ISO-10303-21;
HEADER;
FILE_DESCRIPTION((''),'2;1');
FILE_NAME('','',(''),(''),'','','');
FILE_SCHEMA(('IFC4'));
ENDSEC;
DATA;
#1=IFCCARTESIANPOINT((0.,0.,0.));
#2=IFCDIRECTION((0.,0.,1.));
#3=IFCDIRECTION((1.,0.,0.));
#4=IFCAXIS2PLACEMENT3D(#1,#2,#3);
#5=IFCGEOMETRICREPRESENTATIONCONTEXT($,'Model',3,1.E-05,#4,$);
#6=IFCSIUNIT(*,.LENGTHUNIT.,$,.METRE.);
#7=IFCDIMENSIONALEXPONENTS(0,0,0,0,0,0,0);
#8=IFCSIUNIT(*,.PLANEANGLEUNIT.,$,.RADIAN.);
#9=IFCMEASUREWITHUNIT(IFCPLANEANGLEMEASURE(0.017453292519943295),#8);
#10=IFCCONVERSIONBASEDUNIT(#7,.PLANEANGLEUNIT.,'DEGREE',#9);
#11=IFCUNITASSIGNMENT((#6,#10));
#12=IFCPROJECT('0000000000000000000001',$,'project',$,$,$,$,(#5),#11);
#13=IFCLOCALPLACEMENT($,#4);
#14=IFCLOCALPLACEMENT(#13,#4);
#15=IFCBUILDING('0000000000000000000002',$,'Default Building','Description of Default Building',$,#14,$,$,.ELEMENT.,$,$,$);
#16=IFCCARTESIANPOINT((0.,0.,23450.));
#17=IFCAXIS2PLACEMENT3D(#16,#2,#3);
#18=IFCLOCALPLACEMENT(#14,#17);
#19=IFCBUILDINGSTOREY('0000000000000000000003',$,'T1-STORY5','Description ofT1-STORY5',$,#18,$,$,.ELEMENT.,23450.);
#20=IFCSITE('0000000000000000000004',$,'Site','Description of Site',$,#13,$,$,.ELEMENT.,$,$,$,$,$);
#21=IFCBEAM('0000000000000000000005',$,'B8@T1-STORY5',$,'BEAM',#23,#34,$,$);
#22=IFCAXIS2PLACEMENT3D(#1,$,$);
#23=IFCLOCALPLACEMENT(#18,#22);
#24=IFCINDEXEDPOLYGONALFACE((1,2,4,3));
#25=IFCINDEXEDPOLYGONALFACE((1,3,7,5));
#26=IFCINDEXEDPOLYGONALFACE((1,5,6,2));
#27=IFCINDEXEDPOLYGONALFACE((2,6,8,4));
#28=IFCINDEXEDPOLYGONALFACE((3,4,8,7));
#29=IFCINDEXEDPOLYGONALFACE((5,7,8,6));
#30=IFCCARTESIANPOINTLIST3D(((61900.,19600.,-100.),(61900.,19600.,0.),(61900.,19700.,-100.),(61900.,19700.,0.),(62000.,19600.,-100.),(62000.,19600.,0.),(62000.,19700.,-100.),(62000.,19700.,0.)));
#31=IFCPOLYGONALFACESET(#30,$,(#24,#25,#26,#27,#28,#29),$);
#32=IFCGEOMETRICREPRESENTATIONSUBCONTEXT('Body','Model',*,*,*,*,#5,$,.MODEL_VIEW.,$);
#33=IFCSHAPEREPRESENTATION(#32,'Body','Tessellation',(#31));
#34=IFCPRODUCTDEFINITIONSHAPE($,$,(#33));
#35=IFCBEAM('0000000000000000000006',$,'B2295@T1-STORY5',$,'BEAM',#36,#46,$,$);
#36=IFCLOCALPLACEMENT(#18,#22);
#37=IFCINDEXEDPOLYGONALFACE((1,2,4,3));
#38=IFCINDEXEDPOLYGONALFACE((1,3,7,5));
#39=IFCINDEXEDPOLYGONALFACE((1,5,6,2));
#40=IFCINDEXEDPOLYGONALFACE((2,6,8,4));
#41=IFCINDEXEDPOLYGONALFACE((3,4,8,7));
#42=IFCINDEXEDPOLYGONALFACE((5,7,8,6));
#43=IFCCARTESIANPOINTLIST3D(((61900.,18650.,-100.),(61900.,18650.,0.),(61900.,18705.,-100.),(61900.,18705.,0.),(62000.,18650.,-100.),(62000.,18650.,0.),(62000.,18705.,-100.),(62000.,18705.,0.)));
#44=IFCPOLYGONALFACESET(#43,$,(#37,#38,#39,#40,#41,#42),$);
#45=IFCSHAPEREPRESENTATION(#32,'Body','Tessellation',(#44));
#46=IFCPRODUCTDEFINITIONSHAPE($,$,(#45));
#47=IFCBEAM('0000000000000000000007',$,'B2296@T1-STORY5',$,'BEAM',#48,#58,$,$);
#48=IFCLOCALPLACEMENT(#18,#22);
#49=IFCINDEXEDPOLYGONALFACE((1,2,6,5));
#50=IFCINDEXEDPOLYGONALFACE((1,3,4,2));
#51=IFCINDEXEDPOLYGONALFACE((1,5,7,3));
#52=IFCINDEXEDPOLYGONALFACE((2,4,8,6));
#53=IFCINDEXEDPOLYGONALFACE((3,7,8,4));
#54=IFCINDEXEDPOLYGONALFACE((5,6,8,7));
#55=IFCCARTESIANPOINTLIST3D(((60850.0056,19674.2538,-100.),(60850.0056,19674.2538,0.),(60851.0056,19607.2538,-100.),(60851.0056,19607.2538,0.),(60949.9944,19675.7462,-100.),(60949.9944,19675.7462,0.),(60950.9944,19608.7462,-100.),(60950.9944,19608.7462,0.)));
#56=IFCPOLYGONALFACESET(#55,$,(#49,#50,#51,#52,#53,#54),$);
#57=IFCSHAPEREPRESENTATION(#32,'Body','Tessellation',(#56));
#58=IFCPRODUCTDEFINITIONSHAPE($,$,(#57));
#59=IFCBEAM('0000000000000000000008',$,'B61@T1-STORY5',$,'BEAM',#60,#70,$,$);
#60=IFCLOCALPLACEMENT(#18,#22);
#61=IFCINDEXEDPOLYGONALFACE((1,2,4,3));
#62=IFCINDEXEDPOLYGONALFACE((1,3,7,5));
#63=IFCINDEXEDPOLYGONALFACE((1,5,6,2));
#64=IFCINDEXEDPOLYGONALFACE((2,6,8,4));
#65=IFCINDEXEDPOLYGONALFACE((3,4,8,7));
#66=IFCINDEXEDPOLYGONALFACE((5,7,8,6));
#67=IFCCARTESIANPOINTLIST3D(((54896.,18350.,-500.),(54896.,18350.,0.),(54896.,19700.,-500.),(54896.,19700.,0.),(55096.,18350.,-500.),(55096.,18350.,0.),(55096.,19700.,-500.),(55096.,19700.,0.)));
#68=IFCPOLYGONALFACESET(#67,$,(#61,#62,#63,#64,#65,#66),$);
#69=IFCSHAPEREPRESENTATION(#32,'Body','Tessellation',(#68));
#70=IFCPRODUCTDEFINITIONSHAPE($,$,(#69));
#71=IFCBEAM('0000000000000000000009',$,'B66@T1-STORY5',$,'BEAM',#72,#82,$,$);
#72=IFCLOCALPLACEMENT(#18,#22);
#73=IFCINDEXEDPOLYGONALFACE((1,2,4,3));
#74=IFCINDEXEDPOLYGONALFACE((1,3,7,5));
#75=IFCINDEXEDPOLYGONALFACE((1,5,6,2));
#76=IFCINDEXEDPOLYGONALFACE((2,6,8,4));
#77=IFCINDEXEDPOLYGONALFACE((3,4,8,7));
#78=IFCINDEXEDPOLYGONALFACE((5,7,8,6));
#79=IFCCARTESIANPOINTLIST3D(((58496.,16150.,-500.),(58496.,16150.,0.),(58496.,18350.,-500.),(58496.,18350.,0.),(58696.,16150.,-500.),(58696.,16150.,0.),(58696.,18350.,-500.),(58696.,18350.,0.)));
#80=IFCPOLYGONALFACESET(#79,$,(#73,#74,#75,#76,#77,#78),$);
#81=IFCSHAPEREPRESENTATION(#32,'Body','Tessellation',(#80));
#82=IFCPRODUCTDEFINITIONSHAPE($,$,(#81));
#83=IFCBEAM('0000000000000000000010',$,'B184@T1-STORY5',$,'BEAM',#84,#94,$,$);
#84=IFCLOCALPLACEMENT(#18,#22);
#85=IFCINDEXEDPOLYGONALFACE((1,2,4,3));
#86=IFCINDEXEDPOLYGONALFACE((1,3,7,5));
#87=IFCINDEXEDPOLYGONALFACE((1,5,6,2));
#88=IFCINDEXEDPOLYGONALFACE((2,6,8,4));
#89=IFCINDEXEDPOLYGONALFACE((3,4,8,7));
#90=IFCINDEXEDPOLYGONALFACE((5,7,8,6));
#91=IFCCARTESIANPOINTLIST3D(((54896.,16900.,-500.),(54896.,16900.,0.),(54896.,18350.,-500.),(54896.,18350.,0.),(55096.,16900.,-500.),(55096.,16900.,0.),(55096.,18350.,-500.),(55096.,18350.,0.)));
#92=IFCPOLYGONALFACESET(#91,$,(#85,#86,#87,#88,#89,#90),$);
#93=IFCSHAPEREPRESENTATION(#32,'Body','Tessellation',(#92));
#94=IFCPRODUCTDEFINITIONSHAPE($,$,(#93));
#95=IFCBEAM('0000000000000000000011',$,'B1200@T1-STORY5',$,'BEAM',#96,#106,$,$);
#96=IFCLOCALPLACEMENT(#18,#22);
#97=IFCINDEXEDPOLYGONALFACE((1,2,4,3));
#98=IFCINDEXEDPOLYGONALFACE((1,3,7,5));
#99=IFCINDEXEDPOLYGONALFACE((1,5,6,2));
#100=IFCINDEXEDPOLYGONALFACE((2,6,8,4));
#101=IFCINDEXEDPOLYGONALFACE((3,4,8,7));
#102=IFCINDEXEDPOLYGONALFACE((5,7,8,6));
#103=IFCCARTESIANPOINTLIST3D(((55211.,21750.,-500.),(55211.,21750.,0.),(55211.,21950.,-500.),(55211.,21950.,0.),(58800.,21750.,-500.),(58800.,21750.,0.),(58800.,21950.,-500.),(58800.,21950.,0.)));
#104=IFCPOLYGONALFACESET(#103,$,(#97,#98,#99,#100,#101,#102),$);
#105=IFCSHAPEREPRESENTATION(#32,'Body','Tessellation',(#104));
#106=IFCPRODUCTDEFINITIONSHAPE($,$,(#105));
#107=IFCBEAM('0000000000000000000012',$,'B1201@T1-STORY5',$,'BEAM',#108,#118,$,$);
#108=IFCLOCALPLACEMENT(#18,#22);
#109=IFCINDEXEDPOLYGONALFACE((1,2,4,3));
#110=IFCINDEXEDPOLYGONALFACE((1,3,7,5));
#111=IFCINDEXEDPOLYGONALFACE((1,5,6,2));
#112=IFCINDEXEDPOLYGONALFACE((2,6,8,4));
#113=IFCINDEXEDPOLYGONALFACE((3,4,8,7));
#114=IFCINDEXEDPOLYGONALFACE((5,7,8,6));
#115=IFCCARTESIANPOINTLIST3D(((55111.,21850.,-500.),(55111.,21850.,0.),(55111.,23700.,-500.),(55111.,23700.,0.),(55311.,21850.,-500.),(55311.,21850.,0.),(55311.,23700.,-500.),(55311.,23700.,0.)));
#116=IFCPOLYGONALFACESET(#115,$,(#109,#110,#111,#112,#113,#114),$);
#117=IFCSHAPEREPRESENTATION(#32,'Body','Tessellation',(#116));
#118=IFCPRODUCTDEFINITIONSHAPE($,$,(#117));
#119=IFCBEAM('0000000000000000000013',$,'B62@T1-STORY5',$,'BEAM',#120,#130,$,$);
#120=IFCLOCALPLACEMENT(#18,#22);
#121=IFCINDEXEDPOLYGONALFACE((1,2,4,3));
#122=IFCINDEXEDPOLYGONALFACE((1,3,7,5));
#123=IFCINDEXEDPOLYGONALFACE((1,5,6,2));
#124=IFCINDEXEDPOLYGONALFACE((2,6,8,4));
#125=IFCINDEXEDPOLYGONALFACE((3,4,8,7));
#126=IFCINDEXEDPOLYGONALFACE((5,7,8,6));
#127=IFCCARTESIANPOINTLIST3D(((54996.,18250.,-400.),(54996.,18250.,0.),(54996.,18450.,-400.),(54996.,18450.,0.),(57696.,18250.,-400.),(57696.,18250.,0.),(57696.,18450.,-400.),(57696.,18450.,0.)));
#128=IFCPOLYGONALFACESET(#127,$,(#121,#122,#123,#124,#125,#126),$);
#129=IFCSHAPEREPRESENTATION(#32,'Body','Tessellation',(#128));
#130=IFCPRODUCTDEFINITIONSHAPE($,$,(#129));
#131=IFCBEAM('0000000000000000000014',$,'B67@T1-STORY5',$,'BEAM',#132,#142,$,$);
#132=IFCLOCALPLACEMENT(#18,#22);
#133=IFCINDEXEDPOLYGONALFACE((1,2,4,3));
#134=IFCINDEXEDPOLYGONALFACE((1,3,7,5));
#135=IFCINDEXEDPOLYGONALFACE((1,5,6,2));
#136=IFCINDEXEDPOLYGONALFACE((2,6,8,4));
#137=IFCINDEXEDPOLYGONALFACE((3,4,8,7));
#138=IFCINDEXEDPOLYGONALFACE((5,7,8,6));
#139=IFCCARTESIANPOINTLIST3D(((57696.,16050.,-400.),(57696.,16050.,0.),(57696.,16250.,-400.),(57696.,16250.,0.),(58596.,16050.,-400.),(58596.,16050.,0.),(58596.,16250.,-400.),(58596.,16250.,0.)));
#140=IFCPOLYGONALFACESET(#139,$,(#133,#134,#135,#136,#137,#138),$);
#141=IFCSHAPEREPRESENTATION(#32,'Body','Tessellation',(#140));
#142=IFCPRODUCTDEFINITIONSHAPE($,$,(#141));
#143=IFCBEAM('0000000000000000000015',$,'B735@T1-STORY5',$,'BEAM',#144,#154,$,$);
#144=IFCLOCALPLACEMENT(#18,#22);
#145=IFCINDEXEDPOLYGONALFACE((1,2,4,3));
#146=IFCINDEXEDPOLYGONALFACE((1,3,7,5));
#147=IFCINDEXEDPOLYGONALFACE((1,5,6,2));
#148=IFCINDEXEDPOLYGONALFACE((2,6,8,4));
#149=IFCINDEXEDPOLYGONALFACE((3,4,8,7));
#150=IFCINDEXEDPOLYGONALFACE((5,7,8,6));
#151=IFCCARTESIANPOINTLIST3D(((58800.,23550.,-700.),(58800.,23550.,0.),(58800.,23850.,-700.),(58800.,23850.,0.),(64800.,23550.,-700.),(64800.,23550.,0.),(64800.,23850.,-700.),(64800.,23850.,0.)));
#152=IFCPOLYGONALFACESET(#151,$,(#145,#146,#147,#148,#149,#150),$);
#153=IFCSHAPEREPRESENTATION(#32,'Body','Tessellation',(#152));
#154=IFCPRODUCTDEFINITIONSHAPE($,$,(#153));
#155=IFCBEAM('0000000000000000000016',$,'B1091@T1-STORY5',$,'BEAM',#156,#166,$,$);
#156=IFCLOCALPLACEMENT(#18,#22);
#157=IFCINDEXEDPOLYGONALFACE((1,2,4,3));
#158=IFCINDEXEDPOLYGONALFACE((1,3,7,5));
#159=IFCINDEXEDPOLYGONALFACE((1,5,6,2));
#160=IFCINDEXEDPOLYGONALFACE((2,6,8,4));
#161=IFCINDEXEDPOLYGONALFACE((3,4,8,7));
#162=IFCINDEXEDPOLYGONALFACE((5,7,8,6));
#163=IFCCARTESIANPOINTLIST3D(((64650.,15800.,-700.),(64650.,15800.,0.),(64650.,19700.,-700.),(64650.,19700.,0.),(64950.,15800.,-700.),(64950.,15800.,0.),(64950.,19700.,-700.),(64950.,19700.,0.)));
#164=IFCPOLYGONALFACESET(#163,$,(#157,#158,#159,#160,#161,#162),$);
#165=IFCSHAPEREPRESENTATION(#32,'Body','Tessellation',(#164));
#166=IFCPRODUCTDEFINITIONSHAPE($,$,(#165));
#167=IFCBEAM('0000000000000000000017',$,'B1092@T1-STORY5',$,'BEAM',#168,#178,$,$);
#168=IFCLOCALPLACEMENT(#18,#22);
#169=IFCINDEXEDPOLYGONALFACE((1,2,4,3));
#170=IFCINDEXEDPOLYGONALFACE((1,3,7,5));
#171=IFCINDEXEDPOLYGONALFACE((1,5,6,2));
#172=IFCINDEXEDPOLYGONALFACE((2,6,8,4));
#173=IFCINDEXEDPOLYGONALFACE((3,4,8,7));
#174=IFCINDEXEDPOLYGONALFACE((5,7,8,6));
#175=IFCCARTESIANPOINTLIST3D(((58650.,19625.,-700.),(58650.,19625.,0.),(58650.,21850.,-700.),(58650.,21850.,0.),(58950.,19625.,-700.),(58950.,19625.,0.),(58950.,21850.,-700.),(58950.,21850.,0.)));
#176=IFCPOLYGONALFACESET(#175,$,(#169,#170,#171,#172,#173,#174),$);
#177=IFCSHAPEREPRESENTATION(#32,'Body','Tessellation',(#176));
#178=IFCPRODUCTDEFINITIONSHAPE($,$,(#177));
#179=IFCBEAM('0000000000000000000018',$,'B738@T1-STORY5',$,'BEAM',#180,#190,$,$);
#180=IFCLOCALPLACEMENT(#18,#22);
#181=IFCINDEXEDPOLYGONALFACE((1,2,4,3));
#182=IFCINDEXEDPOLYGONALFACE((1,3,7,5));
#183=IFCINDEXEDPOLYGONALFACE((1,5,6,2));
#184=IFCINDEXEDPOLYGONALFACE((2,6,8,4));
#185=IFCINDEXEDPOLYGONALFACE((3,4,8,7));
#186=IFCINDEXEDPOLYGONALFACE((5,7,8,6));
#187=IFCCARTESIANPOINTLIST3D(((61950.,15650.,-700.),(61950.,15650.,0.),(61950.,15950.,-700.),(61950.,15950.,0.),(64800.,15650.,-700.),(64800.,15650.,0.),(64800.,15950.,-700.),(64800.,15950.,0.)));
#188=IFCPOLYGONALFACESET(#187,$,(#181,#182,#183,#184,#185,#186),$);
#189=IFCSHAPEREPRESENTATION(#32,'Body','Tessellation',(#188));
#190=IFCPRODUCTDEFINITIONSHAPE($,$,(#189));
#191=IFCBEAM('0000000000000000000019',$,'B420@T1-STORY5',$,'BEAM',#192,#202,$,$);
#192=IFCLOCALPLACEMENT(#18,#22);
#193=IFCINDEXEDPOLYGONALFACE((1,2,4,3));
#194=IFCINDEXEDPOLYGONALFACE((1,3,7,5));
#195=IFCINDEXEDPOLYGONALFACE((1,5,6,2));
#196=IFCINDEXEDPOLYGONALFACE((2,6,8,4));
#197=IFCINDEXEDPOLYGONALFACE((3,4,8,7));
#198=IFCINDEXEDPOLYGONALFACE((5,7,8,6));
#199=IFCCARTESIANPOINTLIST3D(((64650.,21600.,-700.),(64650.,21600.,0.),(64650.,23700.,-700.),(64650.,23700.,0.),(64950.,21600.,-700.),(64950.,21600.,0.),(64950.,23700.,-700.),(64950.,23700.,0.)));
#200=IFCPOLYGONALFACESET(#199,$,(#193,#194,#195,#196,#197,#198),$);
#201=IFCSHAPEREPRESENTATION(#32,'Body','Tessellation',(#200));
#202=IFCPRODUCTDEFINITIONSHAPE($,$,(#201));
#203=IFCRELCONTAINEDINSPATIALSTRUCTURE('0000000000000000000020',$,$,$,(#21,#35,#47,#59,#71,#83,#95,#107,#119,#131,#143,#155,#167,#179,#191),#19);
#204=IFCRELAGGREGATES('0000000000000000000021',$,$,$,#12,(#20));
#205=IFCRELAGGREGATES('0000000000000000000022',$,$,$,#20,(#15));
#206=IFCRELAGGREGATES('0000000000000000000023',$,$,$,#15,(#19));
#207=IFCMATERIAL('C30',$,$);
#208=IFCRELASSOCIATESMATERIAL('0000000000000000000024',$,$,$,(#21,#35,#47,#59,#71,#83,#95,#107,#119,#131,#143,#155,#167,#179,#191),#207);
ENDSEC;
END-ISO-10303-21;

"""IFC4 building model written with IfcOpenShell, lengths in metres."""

from ifc_helpers import new_model, entity, si_unit, converted_unit, frame, origin_with_axes, place, context, subcontext, project, spatial, rectangle, extrude, material, element, save


model = new_model("IFC4")

# Units and contexts
model_context = context("Model", 3, precision=1e-05, world=origin_with_axes())
body_context = subcontext(model_context, "Body", "Model", "MODEL_VIEW")
ifc_project = project(units=[si_unit("LENGTHUNIT", "METRE"), converted_unit("PLANEANGLEUNIT", "DEGREE", entity("IfcPlaneAngleMeasure", 0.017453292519943295), si_unit("PLANEANGLEUNIT", "RADIAN"), dimensions=[0, 0, 0, 0, 0, 0, 0])], contexts=[model_context])

# Site, building, storey
site_placement = place(None, origin_with_axes())
site = spatial("IfcSite", under=ifc_project, at=site_placement, Name="Site", Description="Description of Site", CompositionType="ELEMENT")
building_placement = place(site_placement, origin_with_axes())
building = spatial("IfcBuilding", under=site, at=building_placement, Name="Default Building", Description="Description of Default Building", CompositionType="ELEMENT")
storey_placement = place(building_placement, frame((0.0, 0.0, 23450.0), z_axis=(0.0, 0.0, 1.0), x_axis=(1.0, 0.0, 0.0)))
storey = spatial("IfcBuildingStorey", under=building, at=storey_placement, Name="T1-STORY5", Description="Description ofT1-STORY5", CompositionType="ELEMENT", Elevation=23450.0)

# Beams
ifc_material_1 = material(Name="C30")
beam_1_placement = place(storey_placement, frame((61950.0, 19600.0, -50.0), z_axis=(0.0, 1.0, 0.0), x_axis=(-1.0, 0.0, 0.0)))
element("IfcBeam", 1, at=beam_1_placement, inside=storey, material=ifc_material_1, Name="B8@T1-STORY5", ObjectType="BEAM", context=body_context, shape_type="SweptSolid", body=[
    extrude(rectangle(XDim=100.0, YDim=100.0), origin_with_axes(), (0.0, 0.0, 1.0), 100.0),
])
beam_2_placement = place(storey_placement, frame((61950.0, 18650.0, -50.0), z_axis=(0.0, 1.0, 0.0), x_axis=(-1.0, 0.0, 0.0)))
element("IfcBeam", 2, at=beam_2_placement, inside=storey, material=ifc_material_1, Name="B2295@T1-STORY5", ObjectType="BEAM", context=body_context, shape_type="SweptSolid", body=[
    extrude(rectangle(XDim=100.0, YDim=100.0), origin_with_axes(), (0.0, 0.0, 1.0), 55.0),
])
beam_3_placement = place(storey_placement, frame((60901.0, 19608.0, -50.0), z_axis=(-0.014924, 0.999889, 0.0), x_axis=(-0.999889, -0.014924, 0.0)))
element("IfcBeam", 3, at=beam_3_placement, inside=storey, material=ifc_material_1, Name="B2296@T1-STORY5", ObjectType="BEAM", context=body_context, shape_type="SweptSolid", body=[
    extrude(rectangle(XDim=100.0, YDim=100.0), origin_with_axes(), (0.0, 0.0, 1.0), 67.0075),
])
beam_4_placement = place(storey_placement, frame((54996.0, 18350.0, -250.0), z_axis=(0.0, 1.0, 0.0), x_axis=(-1.0, 0.0, 0.0)))
element("IfcBeam", 4, at=beam_4_placement, inside=storey, material=ifc_material_1, Name="B61@T1-STORY5", ObjectType="BEAM", context=body_context, shape_type="SweptSolid", body=[
    extrude(rectangle(XDim=200.0, YDim=500.0), origin_with_axes(), (0.0, 0.0, 1.0), 1350.0),
])
beam_5_placement = place(storey_placement, frame((58596.0, 16150.0, -250.0), z_axis=(0.0, 1.0, 0.0), x_axis=(-1.0, 0.0, 0.0)))
element("IfcBeam", 5, at=beam_5_placement, inside=storey, material=ifc_material_1, Name="B66@T1-STORY5", ObjectType="BEAM", context=body_context, shape_type="SweptSolid", body=[
    extrude(rectangle(XDim=200.0, YDim=500.0), origin_with_axes(), (0.0, 0.0, 1.0), 2200.0),
])
beam_6_placement = place(storey_placement, frame((54996.0, 16900.0, -250.0), z_axis=(0.0, 1.0, 0.0), x_axis=(-1.0, 0.0, 0.0)))
element("IfcBeam", 6, at=beam_6_placement, inside=storey, material=ifc_material_1, Name="B184@T1-STORY5", ObjectType="BEAM", context=body_context, shape_type="SweptSolid", body=[
    extrude(rectangle(XDim=200.0, YDim=500.0), origin_with_axes(), (0.0, 0.0, 1.0), 1450.0),
])
beam_7_placement = place(storey_placement, frame((55211.0, 21850.0, -250.0), z_axis=(1.0, 0.0, 0.0), x_axis=(0.0, 1.0, 0.0)))
element("IfcBeam", 7, at=beam_7_placement, inside=storey, material=ifc_material_1, Name="B1200@T1-STORY5", ObjectType="BEAM", context=body_context, shape_type="SweptSolid", body=[
    extrude(rectangle(XDim=200.0, YDim=500.0), origin_with_axes(), (0.0, 0.0, 1.0), 3589.0),
])
beam_8_placement = place(storey_placement, frame((55211.0, 21850.0, -250.0), z_axis=(0.0, 1.0, 0.0), x_axis=(-1.0, 0.0, 0.0)))
element("IfcBeam", 8, at=beam_8_placement, inside=storey, material=ifc_material_1, Name="B1201@T1-STORY5", ObjectType="BEAM", context=body_context, shape_type="SweptSolid", body=[
    extrude(rectangle(XDim=200.0, YDim=500.0), origin_with_axes(), (0.0, 0.0, 1.0), 1850.0),
])
beam_9_placement = place(storey_placement, frame((54996.0, 18350.0, -200.0), z_axis=(1.0, 0.0, 0.0), x_axis=(0.0, 1.0, 0.0)))
element("IfcBeam", 9, at=beam_9_placement, inside=storey, material=ifc_material_1, Name="B62@T1-STORY5", ObjectType="BEAM", context=body_context, shape_type="SweptSolid", body=[
    extrude(rectangle(XDim=200.0, YDim=400.0), origin_with_axes(), (0.0, 0.0, 1.0), 2700.0),
])
beam_10_placement = place(storey_placement, frame((57696.0, 16150.0, -200.0), z_axis=(1.0, 0.0, 0.0), x_axis=(0.0, 1.0, 0.0)))
element("IfcBeam", 10, at=beam_10_placement, inside=storey, material=ifc_material_1, Name="B67@T1-STORY5", ObjectType="BEAM", context=body_context, shape_type="SweptSolid", body=[
    extrude(rectangle(XDim=200.0, YDim=400.0), origin_with_axes(), (0.0, 0.0, 1.0), 900.0),
])
beam_11_placement = place(storey_placement, frame((58800.0, 23700.0, -350.0), z_axis=(1.0, 0.0, 0.0), x_axis=(0.0, 1.0, 0.0)))
element("IfcBeam", 11, at=beam_11_placement, inside=storey, material=ifc_material_1, Name="B735@T1-STORY5", ObjectType="BEAM", context=body_context, shape_type="SweptSolid", body=[
    extrude(rectangle(XDim=300.0, YDim=700.0), origin_with_axes(), (0.0, 0.0, 1.0), 6000.0),
])
beam_12_placement = place(storey_placement, frame((64800.0, 15800.0, -350.0), z_axis=(0.0, 1.0, 0.0), x_axis=(-1.0, 0.0, 0.0)))
element("IfcBeam", 12, at=beam_12_placement, inside=storey, material=ifc_material_1, Name="B1091@T1-STORY5", ObjectType="BEAM", context=body_context, shape_type="SweptSolid", body=[
    extrude(rectangle(XDim=300.0, YDim=700.0), origin_with_axes(), (0.0, 0.0, 1.0), 3900.0),
])
beam_13_placement = place(storey_placement, frame((58800.0, 19625.0, -350.0), z_axis=(0.0, 1.0, 0.0), x_axis=(-1.0, 0.0, 0.0)))
element("IfcBeam", 13, at=beam_13_placement, inside=storey, material=ifc_material_1, Name="B1092@T1-STORY5", ObjectType="BEAM", context=body_context, shape_type="SweptSolid", body=[
    extrude(rectangle(XDim=300.0, YDim=700.0), origin_with_axes(), (0.0, 0.0, 1.0), 2225.0),
])
beam_14_placement = place(storey_placement, frame((61950.0, 15800.0, -350.0), z_axis=(1.0, 0.0, 0.0), x_axis=(0.0, 1.0, 0.0)))
element("IfcBeam", 14, at=beam_14_placement, inside=storey, material=ifc_material_1, Name="B738@T1-STORY5", ObjectType="BEAM", context=body_context, shape_type="SweptSolid", body=[
    extrude(rectangle(XDim=300.0, YDim=700.0), origin_with_axes(), (0.0, 0.0, 1.0), 2850.0),
])
beam_15_placement = place(storey_placement, frame((64800.0, 21600.0, -350.0), z_axis=(0.0, 1.0, 0.0), x_axis=(-1.0, 0.0, 0.0)))
element("IfcBeam", 15, at=beam_15_placement, inside=storey, material=ifc_material_1, Name="B420@T1-STORY5", ObjectType="BEAM", context=body_context, shape_type="SweptSolid", body=[
    extrude(rectangle(XDim=300.0, YDim=700.0), origin_with_axes(), (0.0, 0.0, 1.0), 2100.0),
])

save(model, "model.ifc")
